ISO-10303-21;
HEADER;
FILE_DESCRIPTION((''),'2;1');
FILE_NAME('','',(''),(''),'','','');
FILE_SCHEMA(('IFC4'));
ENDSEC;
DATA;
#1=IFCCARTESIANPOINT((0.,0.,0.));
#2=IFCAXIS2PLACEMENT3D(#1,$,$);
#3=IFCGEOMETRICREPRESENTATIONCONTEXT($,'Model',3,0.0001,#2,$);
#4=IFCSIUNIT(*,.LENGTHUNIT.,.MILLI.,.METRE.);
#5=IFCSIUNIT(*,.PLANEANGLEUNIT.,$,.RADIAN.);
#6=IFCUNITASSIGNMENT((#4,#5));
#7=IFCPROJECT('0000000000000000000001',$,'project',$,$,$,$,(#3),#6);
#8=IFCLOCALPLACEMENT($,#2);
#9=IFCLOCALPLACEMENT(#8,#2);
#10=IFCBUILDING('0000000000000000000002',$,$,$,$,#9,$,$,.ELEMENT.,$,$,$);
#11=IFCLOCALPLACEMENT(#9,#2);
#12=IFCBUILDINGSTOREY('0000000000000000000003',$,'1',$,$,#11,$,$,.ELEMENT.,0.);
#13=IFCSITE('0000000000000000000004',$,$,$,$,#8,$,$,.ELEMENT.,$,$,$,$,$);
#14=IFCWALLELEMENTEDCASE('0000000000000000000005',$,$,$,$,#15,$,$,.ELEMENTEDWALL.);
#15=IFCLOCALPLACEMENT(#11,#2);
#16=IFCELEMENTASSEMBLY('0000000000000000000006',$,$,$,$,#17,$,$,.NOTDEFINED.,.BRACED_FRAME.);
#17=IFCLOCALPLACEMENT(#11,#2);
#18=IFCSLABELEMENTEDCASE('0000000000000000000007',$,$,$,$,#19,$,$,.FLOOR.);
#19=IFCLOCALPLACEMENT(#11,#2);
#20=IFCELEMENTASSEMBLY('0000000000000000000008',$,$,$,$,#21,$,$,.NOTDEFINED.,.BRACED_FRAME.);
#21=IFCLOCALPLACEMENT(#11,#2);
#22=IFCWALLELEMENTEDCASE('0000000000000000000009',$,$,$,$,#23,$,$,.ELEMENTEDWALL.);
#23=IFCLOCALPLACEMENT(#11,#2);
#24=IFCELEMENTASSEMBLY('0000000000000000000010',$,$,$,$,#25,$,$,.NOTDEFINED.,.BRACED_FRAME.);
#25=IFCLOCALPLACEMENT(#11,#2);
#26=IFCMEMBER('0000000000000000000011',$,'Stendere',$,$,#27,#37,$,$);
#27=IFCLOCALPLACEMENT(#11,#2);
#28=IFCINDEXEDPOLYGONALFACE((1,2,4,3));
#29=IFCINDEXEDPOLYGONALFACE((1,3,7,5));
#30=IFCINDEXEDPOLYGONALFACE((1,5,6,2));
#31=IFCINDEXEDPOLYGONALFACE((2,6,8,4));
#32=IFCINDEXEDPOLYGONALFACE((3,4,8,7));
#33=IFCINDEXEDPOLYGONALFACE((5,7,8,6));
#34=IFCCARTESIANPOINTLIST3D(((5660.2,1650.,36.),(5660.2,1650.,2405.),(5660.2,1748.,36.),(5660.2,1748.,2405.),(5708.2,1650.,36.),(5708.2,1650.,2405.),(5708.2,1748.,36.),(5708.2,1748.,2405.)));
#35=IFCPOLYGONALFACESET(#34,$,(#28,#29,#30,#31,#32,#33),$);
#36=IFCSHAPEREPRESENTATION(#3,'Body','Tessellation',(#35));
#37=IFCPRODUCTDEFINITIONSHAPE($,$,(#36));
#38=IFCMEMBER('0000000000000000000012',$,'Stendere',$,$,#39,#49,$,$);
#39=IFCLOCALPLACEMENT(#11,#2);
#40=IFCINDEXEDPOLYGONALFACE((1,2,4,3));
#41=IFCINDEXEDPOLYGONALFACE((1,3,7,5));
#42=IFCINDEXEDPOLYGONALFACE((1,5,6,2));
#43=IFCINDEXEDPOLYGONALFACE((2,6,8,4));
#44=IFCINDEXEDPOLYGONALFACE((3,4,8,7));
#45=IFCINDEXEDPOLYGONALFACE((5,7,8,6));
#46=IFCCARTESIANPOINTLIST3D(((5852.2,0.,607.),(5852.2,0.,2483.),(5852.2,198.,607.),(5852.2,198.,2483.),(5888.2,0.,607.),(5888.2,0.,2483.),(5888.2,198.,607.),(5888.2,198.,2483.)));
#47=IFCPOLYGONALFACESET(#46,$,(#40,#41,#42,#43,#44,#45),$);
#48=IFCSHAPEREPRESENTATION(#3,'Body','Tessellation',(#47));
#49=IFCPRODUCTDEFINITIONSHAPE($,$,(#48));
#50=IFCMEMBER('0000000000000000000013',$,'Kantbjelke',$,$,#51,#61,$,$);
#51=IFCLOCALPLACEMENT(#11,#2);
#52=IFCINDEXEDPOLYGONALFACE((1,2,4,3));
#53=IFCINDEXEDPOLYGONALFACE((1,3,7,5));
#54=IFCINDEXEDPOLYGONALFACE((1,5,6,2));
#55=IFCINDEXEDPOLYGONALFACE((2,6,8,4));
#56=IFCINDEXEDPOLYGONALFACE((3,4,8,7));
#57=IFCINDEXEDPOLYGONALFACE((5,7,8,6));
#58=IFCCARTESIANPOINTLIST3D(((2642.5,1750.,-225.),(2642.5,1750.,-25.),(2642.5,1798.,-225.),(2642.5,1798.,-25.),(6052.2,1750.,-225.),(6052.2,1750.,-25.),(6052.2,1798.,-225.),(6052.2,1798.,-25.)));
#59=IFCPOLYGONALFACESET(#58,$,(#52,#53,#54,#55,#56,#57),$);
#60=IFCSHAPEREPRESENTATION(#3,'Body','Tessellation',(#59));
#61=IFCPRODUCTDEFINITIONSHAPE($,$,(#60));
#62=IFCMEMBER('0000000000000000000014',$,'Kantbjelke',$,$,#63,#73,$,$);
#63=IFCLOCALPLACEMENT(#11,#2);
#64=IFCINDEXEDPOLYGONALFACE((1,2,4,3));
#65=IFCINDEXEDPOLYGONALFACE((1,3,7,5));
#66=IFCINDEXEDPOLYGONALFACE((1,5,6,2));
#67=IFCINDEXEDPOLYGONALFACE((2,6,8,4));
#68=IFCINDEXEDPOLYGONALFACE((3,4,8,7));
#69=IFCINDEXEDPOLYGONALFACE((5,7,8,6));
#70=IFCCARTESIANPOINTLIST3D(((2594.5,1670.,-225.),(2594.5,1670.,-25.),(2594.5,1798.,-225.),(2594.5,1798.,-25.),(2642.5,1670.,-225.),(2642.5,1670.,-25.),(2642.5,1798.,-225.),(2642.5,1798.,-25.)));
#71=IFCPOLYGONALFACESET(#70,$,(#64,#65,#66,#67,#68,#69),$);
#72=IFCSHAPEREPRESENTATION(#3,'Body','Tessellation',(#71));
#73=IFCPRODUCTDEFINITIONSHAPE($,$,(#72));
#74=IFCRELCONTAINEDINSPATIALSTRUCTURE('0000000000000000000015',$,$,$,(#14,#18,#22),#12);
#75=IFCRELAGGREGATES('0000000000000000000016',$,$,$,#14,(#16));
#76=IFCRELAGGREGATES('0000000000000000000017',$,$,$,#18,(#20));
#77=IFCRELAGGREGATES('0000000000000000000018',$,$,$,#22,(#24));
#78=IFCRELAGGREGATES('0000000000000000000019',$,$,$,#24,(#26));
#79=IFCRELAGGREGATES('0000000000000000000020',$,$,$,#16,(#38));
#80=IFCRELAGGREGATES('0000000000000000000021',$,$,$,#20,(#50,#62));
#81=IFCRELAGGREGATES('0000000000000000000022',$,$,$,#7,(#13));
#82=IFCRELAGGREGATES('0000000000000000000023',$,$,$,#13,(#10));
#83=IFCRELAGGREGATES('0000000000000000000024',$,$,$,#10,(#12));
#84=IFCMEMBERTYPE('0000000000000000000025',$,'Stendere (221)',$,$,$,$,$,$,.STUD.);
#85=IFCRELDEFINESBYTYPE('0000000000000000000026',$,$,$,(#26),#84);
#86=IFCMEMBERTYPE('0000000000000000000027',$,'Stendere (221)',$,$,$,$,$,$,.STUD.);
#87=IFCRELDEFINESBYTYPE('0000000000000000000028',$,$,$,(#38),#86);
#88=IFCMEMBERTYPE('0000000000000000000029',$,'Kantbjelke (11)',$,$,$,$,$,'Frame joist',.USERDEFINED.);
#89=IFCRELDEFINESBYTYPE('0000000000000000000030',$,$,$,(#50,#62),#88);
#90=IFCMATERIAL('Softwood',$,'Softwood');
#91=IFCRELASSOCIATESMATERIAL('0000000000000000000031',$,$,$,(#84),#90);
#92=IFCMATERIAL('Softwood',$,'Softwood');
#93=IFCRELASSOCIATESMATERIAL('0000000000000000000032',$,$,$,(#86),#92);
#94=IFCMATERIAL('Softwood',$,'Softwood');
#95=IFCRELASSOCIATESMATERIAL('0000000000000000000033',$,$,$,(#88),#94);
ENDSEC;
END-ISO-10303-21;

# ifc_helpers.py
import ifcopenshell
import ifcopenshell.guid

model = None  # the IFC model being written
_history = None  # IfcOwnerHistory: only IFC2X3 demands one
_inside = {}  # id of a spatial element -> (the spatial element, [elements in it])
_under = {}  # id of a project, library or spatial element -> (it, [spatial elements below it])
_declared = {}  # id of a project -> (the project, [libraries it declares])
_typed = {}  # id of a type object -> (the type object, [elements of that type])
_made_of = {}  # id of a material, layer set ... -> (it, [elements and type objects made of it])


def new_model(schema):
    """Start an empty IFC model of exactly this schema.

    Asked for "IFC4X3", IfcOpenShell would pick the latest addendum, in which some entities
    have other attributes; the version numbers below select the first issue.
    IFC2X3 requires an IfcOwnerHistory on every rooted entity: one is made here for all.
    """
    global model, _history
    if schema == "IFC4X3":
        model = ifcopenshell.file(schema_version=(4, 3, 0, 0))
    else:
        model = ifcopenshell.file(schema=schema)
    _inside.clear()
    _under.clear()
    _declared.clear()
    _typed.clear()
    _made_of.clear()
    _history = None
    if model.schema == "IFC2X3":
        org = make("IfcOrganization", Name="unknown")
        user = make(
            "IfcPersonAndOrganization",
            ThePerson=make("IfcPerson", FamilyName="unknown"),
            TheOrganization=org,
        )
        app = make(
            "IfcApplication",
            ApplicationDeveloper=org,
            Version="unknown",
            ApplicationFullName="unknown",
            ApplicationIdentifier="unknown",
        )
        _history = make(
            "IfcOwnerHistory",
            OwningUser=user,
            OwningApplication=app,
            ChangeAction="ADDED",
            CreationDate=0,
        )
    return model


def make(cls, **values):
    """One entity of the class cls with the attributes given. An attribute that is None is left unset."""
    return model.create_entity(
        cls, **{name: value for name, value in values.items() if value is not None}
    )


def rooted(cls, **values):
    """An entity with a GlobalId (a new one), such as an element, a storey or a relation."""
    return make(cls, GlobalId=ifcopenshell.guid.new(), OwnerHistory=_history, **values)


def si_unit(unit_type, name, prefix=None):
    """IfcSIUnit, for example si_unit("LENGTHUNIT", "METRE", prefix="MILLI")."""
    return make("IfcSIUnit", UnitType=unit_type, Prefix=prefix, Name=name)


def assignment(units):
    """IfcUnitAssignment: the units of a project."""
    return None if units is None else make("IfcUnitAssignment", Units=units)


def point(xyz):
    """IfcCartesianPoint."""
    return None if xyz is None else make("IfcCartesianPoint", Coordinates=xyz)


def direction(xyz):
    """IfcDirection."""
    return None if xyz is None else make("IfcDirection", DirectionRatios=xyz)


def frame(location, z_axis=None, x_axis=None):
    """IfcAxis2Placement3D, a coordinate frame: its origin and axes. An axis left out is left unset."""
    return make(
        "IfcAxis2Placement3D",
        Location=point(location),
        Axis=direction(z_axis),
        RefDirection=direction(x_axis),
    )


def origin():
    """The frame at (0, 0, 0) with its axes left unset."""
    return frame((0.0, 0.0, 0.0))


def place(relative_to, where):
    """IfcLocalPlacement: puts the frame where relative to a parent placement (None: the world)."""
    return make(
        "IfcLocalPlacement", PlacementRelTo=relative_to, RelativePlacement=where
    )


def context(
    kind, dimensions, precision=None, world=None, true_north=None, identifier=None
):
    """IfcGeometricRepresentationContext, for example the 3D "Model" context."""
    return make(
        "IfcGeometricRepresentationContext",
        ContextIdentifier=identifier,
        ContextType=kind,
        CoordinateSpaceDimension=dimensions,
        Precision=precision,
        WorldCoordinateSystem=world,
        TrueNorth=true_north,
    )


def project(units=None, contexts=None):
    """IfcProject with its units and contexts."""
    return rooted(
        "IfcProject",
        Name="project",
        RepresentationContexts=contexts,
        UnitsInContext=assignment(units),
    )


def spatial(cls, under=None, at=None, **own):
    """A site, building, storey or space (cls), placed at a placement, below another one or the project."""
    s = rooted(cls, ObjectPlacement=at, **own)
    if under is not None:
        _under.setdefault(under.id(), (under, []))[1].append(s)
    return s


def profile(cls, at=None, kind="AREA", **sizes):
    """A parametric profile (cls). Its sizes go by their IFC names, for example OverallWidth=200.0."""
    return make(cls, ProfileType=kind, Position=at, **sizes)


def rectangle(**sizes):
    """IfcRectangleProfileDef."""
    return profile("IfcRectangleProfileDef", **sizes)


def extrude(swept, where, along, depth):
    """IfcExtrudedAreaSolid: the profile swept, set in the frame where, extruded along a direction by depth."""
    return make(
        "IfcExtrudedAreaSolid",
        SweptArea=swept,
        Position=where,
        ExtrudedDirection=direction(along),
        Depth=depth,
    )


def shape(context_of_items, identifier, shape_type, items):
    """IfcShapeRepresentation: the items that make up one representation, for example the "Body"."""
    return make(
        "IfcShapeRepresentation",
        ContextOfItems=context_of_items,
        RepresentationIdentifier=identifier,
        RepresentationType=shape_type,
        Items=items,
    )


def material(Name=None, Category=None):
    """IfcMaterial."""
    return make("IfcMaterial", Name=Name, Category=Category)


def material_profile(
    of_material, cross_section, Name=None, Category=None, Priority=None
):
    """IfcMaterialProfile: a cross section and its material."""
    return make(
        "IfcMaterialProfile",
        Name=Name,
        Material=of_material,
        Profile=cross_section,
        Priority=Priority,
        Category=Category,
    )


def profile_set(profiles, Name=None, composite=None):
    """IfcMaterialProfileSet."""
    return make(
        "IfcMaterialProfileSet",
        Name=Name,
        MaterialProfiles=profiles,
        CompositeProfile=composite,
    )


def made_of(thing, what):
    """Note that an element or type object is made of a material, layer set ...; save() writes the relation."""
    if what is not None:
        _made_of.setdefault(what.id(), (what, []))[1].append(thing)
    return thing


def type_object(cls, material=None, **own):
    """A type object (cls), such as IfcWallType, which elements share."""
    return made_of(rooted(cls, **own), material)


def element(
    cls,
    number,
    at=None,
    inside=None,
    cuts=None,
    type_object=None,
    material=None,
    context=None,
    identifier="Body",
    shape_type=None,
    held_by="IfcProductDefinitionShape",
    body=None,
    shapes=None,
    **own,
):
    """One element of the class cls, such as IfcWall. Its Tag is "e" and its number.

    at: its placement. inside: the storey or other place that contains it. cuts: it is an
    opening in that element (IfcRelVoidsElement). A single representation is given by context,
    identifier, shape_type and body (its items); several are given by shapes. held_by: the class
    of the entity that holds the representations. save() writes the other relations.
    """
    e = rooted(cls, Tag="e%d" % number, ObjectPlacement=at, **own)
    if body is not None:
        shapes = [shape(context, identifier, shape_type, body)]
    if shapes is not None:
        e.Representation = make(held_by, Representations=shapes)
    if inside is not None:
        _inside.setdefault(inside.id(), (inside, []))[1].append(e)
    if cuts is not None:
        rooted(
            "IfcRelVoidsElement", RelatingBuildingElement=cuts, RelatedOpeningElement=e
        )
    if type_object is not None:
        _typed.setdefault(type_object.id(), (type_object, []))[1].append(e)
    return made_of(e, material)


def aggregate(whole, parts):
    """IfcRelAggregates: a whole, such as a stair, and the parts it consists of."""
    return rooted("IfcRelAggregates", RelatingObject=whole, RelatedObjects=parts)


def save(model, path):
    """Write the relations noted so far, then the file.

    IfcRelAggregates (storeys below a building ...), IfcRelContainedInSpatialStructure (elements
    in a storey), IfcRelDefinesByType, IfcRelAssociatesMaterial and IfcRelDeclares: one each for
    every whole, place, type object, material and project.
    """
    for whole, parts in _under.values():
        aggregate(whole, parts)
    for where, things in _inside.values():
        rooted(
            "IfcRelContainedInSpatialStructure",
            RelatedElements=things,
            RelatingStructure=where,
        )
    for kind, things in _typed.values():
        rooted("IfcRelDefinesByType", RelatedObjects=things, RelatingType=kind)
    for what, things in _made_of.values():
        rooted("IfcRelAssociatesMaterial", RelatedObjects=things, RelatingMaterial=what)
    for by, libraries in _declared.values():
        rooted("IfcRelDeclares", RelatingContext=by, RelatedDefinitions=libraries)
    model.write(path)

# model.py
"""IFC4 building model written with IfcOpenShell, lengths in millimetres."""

from ifc_helpers import new_model, si_unit, frame, origin, place, context, project, spatial, rectangle, extrude, material, material_profile, profile_set, type_object, element, aggregate, save


model = new_model("IFC4")

# Units and contexts
model_context = context("Model", 3, precision=0.0001, world=origin())
ifc_project = project(units=[si_unit("LENGTHUNIT", "METRE", prefix="MILLI"), si_unit("PLANEANGLEUNIT", "RADIAN")], contexts=[model_context])

# Site, building, storey
site_placement = place(None, origin())
site = spatial("IfcSite", under=ifc_project, at=site_placement, CompositionType="ELEMENT")
building_placement = place(site_placement, origin())
building = spatial("IfcBuilding", under=site, at=building_placement, CompositionType="ELEMENT")
storey_placement = place(building_placement, origin())
storey = spatial("IfcBuildingStorey", under=building, at=storey_placement, Name="1", CompositionType="ELEMENT", Elevation=0.0)

# Wall, element assembly
wall_1_placement = place(storey_placement, frame((5852.2, 198.0, 535.0), z_axis=(0.0, -1.0, 0.0)))
wall_1 = element("IfcWallElementedCase", 1, at=wall_1_placement, inside=storey, PredefinedType="ELEMENTEDWALL")
assembly_1_placement = place(wall_1_placement, origin())
assembly_1 = element("IfcElementAssembly", 2, at=assembly_1_placement, AssemblyPlace="NOTDEFINED", PredefinedType="BRACED_FRAME")
aggregate(wall_1, [assembly_1])

# Slab, element assembly
slab_placement = place(storey_placement, origin())
slab = element("IfcSlabElementedCase", 3, at=slab_placement, inside=storey, PredefinedType="FLOOR")
assembly_2_placement = place(slab_placement, frame((0.0, 0.0, -225.0)))
assembly_2 = element("IfcElementAssembly", 4, at=assembly_2_placement, AssemblyPlace="NOTDEFINED", PredefinedType="BRACED_FRAME")
aggregate(slab, [assembly_2])

# Wall, element assembly
wall_2_placement = place(storey_placement, frame((2642.5, 1748.0, 0.0), z_axis=(0.0, -1.0, 0.0)))
wall_2 = element("IfcWallElementedCase", 5, at=wall_2_placement, inside=storey, PredefinedType="ELEMENTEDWALL")
assembly_3_placement = place(wall_2_placement, origin())
assembly_3 = element("IfcElementAssembly", 6, at=assembly_3_placement, AssemblyPlace="NOTDEFINED", PredefinedType="BRACED_FRAME")
aggregate(wall_2, [assembly_3])

# Members
ifc_material_1 = material(Name="Softwood", Category="Softwood")
ifc_material_profile_1 = material_profile(ifc_material_1, rectangle(XDim=48.0, YDim=98.0), Name="Stendere (221)")
ifc_profile_set_1 = profile_set([ifc_material_profile_1])
member_type_1 = type_object("IfcMemberType", Name="Stendere (221)", PredefinedType="STUD", material=ifc_profile_set_1)
member_1_placement = place(assembly_3_placement, frame((3041.7, 36.0, 0.0), z_axis=(0.0, 1.0, 0.0), x_axis=(-1.0, 0.0, 0.0)))
member_1 = element("IfcMember", 7, at=member_1_placement, type_object=member_type_1, Name="Stendere", context=model_context, shape_type="SweptSolid", body=[
    extrude(rectangle(XDim=48.0, YDim=98.0), frame((0.0, 49.0, 0.0)), (0.0, 0.0, 1.0), 2369.0),
])
aggregate(assembly_3, [member_1])
ifc_material_2 = material(Name="Softwood", Category="Softwood")
ifc_material_profile_2 = material_profile(ifc_material_2, rectangle(XDim=36.0, YDim=198.0), Name="Stendere (221)")
ifc_profile_set_2 = profile_set([ifc_material_profile_2])
member_type_2 = type_object("IfcMemberType", Name="Stendere (221)", PredefinedType="STUD", material=ifc_profile_set_2)
member_2_placement = place(assembly_1_placement, frame((18.0, 72.0, 0.0), z_axis=(0.0, 1.0, 0.0), x_axis=(-1.0, 0.0, 0.0)))
member_2 = element("IfcMember", 8, at=member_2_placement, type_object=member_type_2, Name="Stendere", context=model_context, shape_type="SweptSolid", body=[
    extrude(rectangle(XDim=36.0, YDim=198.0), frame((0.0, 99.0, 0.0)), (0.0, 0.0, 1.0), 1876.0),
])
aggregate(assembly_1, [member_2])
ifc_material_3 = material(Name="Softwood", Category="Softwood")
ifc_material_profile_3 = material_profile(ifc_material_3, rectangle(XDim=48.0, YDim=200.0), Name="Kantbjelke (11)")
ifc_profile_set_3 = profile_set([ifc_material_profile_3])
member_type_3 = type_object("IfcMemberType", Name="Kantbjelke (11)", ElementType="Frame joist", PredefinedType="USERDEFINED", material=ifc_profile_set_3)
member_3_placement = place(assembly_2_placement, frame((2642.5, 1774.0, 0.0), z_axis=(1.0, 0.0, 0.0), x_axis=(0.0, 1.0, 0.0)))
member_3 = element("IfcMember", 9, at=member_3_placement, type_object=member_type_3, Name="Kantbjelke", context=model_context, shape_type="SweptSolid", body=[
    extrude(rectangle(XDim=48.0, YDim=200.0), frame((0.0, 100.0, 0.0)), (0.0, 0.0, 1.0), 3409.7),
])
member_4_placement = place(assembly_2_placement, frame((2618.5, 1670.0, 0.0), z_axis=(0.0, 1.0, 0.0), x_axis=(-1.0, 0.0, 0.0)))
member_4 = element("IfcMember", 10, at=member_4_placement, type_object=member_type_3, Name="Kantbjelke", context=model_context, shape_type="SweptSolid", body=[
    extrude(rectangle(XDim=48.0, YDim=200.0), frame((0.0, 100.0, 0.0)), (0.0, 0.0, 1.0), 128.0),
])
aggregate(assembly_2, [member_3, member_4])

save(model, "model.ifc")
